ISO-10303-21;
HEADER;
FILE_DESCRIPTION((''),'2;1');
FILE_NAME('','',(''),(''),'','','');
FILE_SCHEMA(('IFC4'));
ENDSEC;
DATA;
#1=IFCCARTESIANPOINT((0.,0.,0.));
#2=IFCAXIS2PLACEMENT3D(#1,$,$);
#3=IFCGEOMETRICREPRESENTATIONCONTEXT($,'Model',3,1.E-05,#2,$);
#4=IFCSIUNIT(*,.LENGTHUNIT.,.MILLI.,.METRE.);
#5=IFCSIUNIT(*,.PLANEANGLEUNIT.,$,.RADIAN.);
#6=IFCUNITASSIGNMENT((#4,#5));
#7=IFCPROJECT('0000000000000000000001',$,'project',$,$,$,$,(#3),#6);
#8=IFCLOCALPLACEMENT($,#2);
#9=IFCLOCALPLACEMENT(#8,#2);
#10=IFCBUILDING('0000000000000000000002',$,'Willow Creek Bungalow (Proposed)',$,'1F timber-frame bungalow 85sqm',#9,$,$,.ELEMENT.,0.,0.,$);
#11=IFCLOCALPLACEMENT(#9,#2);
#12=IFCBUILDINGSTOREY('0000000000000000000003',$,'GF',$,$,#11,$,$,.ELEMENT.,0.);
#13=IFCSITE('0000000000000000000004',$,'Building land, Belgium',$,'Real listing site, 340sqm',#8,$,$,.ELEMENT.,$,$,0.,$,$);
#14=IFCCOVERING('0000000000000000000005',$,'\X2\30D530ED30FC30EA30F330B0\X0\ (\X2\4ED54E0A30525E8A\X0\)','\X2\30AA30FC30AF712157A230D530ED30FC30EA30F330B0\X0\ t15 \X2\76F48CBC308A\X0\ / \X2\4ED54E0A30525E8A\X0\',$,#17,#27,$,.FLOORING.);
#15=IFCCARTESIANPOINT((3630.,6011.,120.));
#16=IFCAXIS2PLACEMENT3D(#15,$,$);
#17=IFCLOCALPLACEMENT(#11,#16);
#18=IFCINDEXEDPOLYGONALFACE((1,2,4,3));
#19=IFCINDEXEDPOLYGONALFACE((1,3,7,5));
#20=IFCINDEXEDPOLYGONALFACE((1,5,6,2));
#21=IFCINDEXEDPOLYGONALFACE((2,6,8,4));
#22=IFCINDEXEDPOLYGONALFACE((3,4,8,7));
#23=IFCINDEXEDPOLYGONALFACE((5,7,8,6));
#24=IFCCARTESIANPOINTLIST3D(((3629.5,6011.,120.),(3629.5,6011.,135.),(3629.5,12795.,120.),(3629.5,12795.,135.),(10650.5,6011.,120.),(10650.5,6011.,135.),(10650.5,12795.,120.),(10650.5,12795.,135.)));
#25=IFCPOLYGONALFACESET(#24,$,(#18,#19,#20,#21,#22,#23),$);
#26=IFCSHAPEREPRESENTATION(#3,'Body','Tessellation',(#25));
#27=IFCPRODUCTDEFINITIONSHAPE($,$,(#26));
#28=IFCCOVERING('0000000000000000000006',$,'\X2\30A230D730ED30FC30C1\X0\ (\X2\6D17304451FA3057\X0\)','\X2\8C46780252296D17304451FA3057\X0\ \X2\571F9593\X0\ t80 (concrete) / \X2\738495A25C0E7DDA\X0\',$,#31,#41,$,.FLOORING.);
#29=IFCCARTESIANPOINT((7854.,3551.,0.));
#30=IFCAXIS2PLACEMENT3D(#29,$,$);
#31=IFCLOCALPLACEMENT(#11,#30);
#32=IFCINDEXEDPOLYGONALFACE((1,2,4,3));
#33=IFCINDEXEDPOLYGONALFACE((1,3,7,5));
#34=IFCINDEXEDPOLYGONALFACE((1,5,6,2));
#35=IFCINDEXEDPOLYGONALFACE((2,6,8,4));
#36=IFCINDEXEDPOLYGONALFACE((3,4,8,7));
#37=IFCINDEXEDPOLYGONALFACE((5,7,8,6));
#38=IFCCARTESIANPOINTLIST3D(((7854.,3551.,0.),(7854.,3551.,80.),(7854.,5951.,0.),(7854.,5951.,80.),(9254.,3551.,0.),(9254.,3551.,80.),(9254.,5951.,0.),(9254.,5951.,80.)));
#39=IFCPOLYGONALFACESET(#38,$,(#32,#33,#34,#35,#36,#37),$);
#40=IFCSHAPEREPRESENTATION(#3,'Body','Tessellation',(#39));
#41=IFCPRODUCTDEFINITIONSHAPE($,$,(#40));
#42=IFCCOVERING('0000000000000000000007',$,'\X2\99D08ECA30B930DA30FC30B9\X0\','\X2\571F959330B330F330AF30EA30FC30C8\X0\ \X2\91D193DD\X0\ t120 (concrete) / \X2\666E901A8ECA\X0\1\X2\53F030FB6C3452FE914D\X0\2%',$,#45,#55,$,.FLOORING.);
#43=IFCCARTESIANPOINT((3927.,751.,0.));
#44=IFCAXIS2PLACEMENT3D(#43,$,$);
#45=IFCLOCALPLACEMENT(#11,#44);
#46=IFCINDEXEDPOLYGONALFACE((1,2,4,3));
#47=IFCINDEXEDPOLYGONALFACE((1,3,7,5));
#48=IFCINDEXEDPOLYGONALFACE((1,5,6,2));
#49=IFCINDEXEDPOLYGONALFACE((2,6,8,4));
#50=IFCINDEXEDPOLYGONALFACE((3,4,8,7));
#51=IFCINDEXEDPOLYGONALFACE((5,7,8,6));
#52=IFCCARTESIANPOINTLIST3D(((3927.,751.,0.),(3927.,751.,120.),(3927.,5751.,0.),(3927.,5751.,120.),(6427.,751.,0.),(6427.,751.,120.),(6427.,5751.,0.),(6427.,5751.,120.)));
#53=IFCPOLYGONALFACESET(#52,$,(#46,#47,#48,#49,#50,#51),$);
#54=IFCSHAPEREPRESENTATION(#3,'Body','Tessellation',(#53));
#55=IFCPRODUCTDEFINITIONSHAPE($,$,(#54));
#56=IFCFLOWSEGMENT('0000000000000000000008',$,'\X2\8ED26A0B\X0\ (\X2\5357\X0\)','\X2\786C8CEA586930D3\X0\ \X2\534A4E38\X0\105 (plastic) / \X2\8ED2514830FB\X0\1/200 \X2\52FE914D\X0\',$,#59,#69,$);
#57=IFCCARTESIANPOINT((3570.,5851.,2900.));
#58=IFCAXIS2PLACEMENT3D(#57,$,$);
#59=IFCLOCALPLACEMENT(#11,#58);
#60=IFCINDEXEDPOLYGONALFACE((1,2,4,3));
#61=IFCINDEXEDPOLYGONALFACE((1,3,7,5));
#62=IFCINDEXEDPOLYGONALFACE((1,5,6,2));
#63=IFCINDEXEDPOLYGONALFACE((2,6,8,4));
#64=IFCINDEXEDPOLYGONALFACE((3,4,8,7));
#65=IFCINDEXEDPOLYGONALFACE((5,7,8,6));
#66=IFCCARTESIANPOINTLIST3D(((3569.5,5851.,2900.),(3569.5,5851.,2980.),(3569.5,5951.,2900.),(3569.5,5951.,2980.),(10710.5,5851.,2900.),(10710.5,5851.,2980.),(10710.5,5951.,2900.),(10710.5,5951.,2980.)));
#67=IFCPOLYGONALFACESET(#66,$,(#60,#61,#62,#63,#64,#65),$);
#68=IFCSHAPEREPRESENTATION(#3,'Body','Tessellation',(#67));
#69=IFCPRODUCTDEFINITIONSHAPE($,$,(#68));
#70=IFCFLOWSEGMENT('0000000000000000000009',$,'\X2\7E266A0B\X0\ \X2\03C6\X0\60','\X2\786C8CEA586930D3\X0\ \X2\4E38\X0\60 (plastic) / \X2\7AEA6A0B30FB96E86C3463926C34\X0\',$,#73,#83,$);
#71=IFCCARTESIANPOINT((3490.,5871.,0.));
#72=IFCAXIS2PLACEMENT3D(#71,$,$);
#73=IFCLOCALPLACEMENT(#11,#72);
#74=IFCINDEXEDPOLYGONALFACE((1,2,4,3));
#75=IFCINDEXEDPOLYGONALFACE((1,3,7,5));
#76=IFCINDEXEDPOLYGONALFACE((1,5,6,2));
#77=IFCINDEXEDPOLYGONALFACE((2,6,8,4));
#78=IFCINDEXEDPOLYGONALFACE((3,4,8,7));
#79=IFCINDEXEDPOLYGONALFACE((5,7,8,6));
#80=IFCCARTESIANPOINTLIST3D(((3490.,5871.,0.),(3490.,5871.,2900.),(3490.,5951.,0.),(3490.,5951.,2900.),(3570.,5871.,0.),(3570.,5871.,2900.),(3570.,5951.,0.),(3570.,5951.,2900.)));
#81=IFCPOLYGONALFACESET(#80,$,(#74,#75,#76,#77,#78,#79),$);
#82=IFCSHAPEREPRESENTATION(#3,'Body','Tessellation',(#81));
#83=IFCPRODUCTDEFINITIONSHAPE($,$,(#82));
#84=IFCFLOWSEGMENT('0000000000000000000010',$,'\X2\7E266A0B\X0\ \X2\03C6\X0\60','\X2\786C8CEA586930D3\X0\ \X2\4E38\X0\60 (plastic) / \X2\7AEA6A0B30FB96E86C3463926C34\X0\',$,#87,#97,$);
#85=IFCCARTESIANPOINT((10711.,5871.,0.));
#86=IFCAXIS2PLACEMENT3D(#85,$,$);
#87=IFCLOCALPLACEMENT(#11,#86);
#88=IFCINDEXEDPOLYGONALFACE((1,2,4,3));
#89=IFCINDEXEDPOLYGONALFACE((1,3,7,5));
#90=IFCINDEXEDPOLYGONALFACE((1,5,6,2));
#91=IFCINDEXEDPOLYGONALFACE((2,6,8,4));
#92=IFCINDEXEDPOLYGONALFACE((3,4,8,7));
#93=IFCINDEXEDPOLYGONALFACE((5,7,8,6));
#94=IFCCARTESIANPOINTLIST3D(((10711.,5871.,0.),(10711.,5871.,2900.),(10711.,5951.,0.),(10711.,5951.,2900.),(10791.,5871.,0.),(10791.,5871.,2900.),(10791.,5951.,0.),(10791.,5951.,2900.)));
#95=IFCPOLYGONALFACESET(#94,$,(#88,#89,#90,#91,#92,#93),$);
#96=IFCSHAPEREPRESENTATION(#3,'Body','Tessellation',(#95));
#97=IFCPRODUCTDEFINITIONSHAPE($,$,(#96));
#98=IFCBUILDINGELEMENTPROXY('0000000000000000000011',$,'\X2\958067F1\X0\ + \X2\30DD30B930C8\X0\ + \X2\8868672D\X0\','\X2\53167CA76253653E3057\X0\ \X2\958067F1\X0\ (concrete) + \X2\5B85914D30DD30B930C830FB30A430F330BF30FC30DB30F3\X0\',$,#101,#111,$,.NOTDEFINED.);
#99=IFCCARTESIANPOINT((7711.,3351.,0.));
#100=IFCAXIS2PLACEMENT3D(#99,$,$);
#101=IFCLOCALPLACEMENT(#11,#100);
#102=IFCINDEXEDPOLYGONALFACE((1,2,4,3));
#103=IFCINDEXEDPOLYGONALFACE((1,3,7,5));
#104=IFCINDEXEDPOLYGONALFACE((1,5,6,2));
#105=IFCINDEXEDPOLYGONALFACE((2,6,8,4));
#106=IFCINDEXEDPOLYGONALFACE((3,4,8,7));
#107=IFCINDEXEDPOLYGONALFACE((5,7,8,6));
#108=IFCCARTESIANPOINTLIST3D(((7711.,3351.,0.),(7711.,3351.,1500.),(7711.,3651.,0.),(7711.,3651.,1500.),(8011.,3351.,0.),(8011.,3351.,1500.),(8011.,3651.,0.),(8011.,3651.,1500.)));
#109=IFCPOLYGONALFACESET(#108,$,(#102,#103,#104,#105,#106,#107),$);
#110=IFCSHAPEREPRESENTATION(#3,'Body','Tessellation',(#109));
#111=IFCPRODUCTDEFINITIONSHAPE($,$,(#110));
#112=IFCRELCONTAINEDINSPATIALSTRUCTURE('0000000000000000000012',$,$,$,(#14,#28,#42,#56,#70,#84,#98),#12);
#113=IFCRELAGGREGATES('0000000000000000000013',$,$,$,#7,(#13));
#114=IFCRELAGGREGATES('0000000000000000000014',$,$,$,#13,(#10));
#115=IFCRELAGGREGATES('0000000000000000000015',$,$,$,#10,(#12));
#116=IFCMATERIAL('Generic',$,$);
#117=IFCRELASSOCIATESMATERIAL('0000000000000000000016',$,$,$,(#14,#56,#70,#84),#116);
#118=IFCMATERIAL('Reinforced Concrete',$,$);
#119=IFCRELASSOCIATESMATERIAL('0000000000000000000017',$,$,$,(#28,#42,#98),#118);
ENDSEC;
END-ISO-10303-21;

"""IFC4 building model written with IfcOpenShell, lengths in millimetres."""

from ifc_helpers import new_model, si_unit, frame, frame_2d, origin, place, context, project, spatial, rectangle, extrude, material, element, save


model = new_model("IFC4")

# Units and contexts
model_context = context("Model", 3, precision=1e-05, world=origin())
ifc_project = project(units=[si_unit("LENGTHUNIT", "METRE", prefix="MILLI"), si_unit("PLANEANGLEUNIT", "RADIAN")], contexts=[model_context])

# Site, building, storey
site_placement = place(None, origin())
site = spatial("IfcSite", under=ifc_project, at=site_placement, Name="Building land, Belgium", ObjectType="Real listing site, 340sqm", CompositionType="ELEMENT", RefElevation=0.0)
building_placement = place(site_placement, origin())
building = spatial("IfcBuilding", under=site, at=building_placement, Name="Willow Creek Bungalow (Proposed)", ObjectType="1F timber-frame bungalow 85sqm", CompositionType="ELEMENT", ElevationOfRefHeight=0.0, ElevationOfTerrain=0.0)
storey_placement = place(building_placement, origin())
storey = spatial("IfcBuildingStorey", under=building, at=storey_placement, Name="GF", CompositionType="ELEMENT", Elevation=0.0)

# Shared definitions
ifc_material_1 = material(Name="Reinforced Concrete")

# Coverings
ifc_material_2 = material(Name="Generic")
covering_1_placement = place(storey_placement, frame((3630.0, 6011.0, 120.0)))
element("IfcCovering", 1, at=covering_1_placement, inside=storey, material=ifc_material_2, Name="フローリング (仕上げ床)", Description="オーク無垢フローリング t15 直貼り / 仕上げ床", PredefinedType="FLOORING", context=model_context, shape_type="SweptSolid", body=[
    extrude(rectangle(XDim=7021.0, YDim=6784.0, at=frame_2d((3510.0, 3392.0))), frame((3630.0, 6011.0, 120.0)), (0.0, 0.0, 1.0), 15.0),
])
covering_2_placement = place(storey_placement, frame((7854.0, 3551.0, 0.0)))
element("IfcCovering", 2, at=covering_2_placement, inside=storey, material=ifc_material_1, Name="アプローチ (洗い出し)", Description="豆砂利洗い出し 土間 t80 (concrete) / 玄関導線", PredefinedType="FLOORING", context=model_context, shape_type="SweptSolid", body=[
    extrude(rectangle(XDim=1400.0, YDim=2400.0, at=frame_2d((700.0, 1200.0))), frame((7854.0, 3551.0, 0.0)), (0.0, 0.0, 1.0), 80.0),
])
covering_3_placement = place(storey_placement, frame((3927.0, 751.0, 0.0)))
element("IfcCovering", 3, at=covering_3_placement, inside=storey, material=ifc_material_1, Name="駐車スペース", Description="土間コンクリート 金鏝 t120 (concrete) / 普通車1台・水勾配2%", PredefinedType="FLOORING", context=model_context, shape_type="SweptSolid", body=[
    extrude(rectangle(XDim=2500.0, YDim=5000.0, at=frame_2d((1250.0, 2500.0))), frame((3927.0, 751.0, 0.0)), (0.0, 0.0, 1.0), 120.0),
])

# Flow segments
flow_segment_1_placement = place(storey_placement, frame((3570.0, 5851.0, 2900.0)))
element("IfcFlowSegment", 4, at=flow_segment_1_placement, inside=storey, material=ifc_material_2, Name="軒樋 (南)", Description="硬質塩ビ 半丸105 (plastic) / 軒先・1/200 勾配", context=model_context, shape_type="SweptSolid", body=[
    extrude(rectangle(XDim=7141.0, YDim=100.0, at=frame_2d((3570.0, 50.0))), frame((3570.0, 5851.0, 2900.0)), (0.0, 0.0, 1.0), 80.0),
])
flow_segment_2_placement = place(storey_placement, frame((3490.0, 5871.0, 0.0)))
element("IfcFlowSegment", 5, at=flow_segment_2_placement, inside=storey, material=ifc_material_2, Name="縦樋 φ60", Description="硬質塩ビ 丸60 (plastic) / 竪樋・雨水排水", context=model_context, shape_type="SweptSolid", body=[
    extrude(rectangle(XDim=80.0, YDim=80.0, at=frame_2d((40.0, 40.0))), frame((3490.0, 5871.0, 0.0)), (0.0, 0.0, 1.0), 2900.0),
])
flow_segment_3_placement = place(storey_placement, frame((10711.0, 5871.0, 0.0)))
element("IfcFlowSegment", 6, at=flow_segment_3_placement, inside=storey, material=ifc_material_2, Name="縦樋 φ60", Description="硬質塩ビ 丸60 (plastic) / 竪樋・雨水排水", context=model_context, shape_type="SweptSolid", body=[
    extrude(rectangle(XDim=80.0, YDim=80.0, at=frame_2d((40.0, 40.0))), frame((10711.0, 5871.0, 0.0)), (0.0, 0.0, 1.0), 2900.0),
])

# Building element proxy
proxy_placement = place(storey_placement, frame((7711.0, 3351.0, 0.0)))
element("IfcBuildingElementProxy", 7, at=proxy_placement, inside=storey, material=ifc_material_1, Name="門柱 + ポスト + 表札", Description="化粧打放し 門柱 (concrete) + 宅配ポスト・インターホン", PredefinedType="NOTDEFINED", context=model_context, shape_type="SweptSolid", body=[
    extrude(rectangle(XDim=300.0, YDim=300.0, at=frame_2d((150.0, 150.0))), frame((7711.0, 3351.0, 0.0)), (0.0, 0.0, 1.0), 1500.0),
])

save(model, "model.ifc")
